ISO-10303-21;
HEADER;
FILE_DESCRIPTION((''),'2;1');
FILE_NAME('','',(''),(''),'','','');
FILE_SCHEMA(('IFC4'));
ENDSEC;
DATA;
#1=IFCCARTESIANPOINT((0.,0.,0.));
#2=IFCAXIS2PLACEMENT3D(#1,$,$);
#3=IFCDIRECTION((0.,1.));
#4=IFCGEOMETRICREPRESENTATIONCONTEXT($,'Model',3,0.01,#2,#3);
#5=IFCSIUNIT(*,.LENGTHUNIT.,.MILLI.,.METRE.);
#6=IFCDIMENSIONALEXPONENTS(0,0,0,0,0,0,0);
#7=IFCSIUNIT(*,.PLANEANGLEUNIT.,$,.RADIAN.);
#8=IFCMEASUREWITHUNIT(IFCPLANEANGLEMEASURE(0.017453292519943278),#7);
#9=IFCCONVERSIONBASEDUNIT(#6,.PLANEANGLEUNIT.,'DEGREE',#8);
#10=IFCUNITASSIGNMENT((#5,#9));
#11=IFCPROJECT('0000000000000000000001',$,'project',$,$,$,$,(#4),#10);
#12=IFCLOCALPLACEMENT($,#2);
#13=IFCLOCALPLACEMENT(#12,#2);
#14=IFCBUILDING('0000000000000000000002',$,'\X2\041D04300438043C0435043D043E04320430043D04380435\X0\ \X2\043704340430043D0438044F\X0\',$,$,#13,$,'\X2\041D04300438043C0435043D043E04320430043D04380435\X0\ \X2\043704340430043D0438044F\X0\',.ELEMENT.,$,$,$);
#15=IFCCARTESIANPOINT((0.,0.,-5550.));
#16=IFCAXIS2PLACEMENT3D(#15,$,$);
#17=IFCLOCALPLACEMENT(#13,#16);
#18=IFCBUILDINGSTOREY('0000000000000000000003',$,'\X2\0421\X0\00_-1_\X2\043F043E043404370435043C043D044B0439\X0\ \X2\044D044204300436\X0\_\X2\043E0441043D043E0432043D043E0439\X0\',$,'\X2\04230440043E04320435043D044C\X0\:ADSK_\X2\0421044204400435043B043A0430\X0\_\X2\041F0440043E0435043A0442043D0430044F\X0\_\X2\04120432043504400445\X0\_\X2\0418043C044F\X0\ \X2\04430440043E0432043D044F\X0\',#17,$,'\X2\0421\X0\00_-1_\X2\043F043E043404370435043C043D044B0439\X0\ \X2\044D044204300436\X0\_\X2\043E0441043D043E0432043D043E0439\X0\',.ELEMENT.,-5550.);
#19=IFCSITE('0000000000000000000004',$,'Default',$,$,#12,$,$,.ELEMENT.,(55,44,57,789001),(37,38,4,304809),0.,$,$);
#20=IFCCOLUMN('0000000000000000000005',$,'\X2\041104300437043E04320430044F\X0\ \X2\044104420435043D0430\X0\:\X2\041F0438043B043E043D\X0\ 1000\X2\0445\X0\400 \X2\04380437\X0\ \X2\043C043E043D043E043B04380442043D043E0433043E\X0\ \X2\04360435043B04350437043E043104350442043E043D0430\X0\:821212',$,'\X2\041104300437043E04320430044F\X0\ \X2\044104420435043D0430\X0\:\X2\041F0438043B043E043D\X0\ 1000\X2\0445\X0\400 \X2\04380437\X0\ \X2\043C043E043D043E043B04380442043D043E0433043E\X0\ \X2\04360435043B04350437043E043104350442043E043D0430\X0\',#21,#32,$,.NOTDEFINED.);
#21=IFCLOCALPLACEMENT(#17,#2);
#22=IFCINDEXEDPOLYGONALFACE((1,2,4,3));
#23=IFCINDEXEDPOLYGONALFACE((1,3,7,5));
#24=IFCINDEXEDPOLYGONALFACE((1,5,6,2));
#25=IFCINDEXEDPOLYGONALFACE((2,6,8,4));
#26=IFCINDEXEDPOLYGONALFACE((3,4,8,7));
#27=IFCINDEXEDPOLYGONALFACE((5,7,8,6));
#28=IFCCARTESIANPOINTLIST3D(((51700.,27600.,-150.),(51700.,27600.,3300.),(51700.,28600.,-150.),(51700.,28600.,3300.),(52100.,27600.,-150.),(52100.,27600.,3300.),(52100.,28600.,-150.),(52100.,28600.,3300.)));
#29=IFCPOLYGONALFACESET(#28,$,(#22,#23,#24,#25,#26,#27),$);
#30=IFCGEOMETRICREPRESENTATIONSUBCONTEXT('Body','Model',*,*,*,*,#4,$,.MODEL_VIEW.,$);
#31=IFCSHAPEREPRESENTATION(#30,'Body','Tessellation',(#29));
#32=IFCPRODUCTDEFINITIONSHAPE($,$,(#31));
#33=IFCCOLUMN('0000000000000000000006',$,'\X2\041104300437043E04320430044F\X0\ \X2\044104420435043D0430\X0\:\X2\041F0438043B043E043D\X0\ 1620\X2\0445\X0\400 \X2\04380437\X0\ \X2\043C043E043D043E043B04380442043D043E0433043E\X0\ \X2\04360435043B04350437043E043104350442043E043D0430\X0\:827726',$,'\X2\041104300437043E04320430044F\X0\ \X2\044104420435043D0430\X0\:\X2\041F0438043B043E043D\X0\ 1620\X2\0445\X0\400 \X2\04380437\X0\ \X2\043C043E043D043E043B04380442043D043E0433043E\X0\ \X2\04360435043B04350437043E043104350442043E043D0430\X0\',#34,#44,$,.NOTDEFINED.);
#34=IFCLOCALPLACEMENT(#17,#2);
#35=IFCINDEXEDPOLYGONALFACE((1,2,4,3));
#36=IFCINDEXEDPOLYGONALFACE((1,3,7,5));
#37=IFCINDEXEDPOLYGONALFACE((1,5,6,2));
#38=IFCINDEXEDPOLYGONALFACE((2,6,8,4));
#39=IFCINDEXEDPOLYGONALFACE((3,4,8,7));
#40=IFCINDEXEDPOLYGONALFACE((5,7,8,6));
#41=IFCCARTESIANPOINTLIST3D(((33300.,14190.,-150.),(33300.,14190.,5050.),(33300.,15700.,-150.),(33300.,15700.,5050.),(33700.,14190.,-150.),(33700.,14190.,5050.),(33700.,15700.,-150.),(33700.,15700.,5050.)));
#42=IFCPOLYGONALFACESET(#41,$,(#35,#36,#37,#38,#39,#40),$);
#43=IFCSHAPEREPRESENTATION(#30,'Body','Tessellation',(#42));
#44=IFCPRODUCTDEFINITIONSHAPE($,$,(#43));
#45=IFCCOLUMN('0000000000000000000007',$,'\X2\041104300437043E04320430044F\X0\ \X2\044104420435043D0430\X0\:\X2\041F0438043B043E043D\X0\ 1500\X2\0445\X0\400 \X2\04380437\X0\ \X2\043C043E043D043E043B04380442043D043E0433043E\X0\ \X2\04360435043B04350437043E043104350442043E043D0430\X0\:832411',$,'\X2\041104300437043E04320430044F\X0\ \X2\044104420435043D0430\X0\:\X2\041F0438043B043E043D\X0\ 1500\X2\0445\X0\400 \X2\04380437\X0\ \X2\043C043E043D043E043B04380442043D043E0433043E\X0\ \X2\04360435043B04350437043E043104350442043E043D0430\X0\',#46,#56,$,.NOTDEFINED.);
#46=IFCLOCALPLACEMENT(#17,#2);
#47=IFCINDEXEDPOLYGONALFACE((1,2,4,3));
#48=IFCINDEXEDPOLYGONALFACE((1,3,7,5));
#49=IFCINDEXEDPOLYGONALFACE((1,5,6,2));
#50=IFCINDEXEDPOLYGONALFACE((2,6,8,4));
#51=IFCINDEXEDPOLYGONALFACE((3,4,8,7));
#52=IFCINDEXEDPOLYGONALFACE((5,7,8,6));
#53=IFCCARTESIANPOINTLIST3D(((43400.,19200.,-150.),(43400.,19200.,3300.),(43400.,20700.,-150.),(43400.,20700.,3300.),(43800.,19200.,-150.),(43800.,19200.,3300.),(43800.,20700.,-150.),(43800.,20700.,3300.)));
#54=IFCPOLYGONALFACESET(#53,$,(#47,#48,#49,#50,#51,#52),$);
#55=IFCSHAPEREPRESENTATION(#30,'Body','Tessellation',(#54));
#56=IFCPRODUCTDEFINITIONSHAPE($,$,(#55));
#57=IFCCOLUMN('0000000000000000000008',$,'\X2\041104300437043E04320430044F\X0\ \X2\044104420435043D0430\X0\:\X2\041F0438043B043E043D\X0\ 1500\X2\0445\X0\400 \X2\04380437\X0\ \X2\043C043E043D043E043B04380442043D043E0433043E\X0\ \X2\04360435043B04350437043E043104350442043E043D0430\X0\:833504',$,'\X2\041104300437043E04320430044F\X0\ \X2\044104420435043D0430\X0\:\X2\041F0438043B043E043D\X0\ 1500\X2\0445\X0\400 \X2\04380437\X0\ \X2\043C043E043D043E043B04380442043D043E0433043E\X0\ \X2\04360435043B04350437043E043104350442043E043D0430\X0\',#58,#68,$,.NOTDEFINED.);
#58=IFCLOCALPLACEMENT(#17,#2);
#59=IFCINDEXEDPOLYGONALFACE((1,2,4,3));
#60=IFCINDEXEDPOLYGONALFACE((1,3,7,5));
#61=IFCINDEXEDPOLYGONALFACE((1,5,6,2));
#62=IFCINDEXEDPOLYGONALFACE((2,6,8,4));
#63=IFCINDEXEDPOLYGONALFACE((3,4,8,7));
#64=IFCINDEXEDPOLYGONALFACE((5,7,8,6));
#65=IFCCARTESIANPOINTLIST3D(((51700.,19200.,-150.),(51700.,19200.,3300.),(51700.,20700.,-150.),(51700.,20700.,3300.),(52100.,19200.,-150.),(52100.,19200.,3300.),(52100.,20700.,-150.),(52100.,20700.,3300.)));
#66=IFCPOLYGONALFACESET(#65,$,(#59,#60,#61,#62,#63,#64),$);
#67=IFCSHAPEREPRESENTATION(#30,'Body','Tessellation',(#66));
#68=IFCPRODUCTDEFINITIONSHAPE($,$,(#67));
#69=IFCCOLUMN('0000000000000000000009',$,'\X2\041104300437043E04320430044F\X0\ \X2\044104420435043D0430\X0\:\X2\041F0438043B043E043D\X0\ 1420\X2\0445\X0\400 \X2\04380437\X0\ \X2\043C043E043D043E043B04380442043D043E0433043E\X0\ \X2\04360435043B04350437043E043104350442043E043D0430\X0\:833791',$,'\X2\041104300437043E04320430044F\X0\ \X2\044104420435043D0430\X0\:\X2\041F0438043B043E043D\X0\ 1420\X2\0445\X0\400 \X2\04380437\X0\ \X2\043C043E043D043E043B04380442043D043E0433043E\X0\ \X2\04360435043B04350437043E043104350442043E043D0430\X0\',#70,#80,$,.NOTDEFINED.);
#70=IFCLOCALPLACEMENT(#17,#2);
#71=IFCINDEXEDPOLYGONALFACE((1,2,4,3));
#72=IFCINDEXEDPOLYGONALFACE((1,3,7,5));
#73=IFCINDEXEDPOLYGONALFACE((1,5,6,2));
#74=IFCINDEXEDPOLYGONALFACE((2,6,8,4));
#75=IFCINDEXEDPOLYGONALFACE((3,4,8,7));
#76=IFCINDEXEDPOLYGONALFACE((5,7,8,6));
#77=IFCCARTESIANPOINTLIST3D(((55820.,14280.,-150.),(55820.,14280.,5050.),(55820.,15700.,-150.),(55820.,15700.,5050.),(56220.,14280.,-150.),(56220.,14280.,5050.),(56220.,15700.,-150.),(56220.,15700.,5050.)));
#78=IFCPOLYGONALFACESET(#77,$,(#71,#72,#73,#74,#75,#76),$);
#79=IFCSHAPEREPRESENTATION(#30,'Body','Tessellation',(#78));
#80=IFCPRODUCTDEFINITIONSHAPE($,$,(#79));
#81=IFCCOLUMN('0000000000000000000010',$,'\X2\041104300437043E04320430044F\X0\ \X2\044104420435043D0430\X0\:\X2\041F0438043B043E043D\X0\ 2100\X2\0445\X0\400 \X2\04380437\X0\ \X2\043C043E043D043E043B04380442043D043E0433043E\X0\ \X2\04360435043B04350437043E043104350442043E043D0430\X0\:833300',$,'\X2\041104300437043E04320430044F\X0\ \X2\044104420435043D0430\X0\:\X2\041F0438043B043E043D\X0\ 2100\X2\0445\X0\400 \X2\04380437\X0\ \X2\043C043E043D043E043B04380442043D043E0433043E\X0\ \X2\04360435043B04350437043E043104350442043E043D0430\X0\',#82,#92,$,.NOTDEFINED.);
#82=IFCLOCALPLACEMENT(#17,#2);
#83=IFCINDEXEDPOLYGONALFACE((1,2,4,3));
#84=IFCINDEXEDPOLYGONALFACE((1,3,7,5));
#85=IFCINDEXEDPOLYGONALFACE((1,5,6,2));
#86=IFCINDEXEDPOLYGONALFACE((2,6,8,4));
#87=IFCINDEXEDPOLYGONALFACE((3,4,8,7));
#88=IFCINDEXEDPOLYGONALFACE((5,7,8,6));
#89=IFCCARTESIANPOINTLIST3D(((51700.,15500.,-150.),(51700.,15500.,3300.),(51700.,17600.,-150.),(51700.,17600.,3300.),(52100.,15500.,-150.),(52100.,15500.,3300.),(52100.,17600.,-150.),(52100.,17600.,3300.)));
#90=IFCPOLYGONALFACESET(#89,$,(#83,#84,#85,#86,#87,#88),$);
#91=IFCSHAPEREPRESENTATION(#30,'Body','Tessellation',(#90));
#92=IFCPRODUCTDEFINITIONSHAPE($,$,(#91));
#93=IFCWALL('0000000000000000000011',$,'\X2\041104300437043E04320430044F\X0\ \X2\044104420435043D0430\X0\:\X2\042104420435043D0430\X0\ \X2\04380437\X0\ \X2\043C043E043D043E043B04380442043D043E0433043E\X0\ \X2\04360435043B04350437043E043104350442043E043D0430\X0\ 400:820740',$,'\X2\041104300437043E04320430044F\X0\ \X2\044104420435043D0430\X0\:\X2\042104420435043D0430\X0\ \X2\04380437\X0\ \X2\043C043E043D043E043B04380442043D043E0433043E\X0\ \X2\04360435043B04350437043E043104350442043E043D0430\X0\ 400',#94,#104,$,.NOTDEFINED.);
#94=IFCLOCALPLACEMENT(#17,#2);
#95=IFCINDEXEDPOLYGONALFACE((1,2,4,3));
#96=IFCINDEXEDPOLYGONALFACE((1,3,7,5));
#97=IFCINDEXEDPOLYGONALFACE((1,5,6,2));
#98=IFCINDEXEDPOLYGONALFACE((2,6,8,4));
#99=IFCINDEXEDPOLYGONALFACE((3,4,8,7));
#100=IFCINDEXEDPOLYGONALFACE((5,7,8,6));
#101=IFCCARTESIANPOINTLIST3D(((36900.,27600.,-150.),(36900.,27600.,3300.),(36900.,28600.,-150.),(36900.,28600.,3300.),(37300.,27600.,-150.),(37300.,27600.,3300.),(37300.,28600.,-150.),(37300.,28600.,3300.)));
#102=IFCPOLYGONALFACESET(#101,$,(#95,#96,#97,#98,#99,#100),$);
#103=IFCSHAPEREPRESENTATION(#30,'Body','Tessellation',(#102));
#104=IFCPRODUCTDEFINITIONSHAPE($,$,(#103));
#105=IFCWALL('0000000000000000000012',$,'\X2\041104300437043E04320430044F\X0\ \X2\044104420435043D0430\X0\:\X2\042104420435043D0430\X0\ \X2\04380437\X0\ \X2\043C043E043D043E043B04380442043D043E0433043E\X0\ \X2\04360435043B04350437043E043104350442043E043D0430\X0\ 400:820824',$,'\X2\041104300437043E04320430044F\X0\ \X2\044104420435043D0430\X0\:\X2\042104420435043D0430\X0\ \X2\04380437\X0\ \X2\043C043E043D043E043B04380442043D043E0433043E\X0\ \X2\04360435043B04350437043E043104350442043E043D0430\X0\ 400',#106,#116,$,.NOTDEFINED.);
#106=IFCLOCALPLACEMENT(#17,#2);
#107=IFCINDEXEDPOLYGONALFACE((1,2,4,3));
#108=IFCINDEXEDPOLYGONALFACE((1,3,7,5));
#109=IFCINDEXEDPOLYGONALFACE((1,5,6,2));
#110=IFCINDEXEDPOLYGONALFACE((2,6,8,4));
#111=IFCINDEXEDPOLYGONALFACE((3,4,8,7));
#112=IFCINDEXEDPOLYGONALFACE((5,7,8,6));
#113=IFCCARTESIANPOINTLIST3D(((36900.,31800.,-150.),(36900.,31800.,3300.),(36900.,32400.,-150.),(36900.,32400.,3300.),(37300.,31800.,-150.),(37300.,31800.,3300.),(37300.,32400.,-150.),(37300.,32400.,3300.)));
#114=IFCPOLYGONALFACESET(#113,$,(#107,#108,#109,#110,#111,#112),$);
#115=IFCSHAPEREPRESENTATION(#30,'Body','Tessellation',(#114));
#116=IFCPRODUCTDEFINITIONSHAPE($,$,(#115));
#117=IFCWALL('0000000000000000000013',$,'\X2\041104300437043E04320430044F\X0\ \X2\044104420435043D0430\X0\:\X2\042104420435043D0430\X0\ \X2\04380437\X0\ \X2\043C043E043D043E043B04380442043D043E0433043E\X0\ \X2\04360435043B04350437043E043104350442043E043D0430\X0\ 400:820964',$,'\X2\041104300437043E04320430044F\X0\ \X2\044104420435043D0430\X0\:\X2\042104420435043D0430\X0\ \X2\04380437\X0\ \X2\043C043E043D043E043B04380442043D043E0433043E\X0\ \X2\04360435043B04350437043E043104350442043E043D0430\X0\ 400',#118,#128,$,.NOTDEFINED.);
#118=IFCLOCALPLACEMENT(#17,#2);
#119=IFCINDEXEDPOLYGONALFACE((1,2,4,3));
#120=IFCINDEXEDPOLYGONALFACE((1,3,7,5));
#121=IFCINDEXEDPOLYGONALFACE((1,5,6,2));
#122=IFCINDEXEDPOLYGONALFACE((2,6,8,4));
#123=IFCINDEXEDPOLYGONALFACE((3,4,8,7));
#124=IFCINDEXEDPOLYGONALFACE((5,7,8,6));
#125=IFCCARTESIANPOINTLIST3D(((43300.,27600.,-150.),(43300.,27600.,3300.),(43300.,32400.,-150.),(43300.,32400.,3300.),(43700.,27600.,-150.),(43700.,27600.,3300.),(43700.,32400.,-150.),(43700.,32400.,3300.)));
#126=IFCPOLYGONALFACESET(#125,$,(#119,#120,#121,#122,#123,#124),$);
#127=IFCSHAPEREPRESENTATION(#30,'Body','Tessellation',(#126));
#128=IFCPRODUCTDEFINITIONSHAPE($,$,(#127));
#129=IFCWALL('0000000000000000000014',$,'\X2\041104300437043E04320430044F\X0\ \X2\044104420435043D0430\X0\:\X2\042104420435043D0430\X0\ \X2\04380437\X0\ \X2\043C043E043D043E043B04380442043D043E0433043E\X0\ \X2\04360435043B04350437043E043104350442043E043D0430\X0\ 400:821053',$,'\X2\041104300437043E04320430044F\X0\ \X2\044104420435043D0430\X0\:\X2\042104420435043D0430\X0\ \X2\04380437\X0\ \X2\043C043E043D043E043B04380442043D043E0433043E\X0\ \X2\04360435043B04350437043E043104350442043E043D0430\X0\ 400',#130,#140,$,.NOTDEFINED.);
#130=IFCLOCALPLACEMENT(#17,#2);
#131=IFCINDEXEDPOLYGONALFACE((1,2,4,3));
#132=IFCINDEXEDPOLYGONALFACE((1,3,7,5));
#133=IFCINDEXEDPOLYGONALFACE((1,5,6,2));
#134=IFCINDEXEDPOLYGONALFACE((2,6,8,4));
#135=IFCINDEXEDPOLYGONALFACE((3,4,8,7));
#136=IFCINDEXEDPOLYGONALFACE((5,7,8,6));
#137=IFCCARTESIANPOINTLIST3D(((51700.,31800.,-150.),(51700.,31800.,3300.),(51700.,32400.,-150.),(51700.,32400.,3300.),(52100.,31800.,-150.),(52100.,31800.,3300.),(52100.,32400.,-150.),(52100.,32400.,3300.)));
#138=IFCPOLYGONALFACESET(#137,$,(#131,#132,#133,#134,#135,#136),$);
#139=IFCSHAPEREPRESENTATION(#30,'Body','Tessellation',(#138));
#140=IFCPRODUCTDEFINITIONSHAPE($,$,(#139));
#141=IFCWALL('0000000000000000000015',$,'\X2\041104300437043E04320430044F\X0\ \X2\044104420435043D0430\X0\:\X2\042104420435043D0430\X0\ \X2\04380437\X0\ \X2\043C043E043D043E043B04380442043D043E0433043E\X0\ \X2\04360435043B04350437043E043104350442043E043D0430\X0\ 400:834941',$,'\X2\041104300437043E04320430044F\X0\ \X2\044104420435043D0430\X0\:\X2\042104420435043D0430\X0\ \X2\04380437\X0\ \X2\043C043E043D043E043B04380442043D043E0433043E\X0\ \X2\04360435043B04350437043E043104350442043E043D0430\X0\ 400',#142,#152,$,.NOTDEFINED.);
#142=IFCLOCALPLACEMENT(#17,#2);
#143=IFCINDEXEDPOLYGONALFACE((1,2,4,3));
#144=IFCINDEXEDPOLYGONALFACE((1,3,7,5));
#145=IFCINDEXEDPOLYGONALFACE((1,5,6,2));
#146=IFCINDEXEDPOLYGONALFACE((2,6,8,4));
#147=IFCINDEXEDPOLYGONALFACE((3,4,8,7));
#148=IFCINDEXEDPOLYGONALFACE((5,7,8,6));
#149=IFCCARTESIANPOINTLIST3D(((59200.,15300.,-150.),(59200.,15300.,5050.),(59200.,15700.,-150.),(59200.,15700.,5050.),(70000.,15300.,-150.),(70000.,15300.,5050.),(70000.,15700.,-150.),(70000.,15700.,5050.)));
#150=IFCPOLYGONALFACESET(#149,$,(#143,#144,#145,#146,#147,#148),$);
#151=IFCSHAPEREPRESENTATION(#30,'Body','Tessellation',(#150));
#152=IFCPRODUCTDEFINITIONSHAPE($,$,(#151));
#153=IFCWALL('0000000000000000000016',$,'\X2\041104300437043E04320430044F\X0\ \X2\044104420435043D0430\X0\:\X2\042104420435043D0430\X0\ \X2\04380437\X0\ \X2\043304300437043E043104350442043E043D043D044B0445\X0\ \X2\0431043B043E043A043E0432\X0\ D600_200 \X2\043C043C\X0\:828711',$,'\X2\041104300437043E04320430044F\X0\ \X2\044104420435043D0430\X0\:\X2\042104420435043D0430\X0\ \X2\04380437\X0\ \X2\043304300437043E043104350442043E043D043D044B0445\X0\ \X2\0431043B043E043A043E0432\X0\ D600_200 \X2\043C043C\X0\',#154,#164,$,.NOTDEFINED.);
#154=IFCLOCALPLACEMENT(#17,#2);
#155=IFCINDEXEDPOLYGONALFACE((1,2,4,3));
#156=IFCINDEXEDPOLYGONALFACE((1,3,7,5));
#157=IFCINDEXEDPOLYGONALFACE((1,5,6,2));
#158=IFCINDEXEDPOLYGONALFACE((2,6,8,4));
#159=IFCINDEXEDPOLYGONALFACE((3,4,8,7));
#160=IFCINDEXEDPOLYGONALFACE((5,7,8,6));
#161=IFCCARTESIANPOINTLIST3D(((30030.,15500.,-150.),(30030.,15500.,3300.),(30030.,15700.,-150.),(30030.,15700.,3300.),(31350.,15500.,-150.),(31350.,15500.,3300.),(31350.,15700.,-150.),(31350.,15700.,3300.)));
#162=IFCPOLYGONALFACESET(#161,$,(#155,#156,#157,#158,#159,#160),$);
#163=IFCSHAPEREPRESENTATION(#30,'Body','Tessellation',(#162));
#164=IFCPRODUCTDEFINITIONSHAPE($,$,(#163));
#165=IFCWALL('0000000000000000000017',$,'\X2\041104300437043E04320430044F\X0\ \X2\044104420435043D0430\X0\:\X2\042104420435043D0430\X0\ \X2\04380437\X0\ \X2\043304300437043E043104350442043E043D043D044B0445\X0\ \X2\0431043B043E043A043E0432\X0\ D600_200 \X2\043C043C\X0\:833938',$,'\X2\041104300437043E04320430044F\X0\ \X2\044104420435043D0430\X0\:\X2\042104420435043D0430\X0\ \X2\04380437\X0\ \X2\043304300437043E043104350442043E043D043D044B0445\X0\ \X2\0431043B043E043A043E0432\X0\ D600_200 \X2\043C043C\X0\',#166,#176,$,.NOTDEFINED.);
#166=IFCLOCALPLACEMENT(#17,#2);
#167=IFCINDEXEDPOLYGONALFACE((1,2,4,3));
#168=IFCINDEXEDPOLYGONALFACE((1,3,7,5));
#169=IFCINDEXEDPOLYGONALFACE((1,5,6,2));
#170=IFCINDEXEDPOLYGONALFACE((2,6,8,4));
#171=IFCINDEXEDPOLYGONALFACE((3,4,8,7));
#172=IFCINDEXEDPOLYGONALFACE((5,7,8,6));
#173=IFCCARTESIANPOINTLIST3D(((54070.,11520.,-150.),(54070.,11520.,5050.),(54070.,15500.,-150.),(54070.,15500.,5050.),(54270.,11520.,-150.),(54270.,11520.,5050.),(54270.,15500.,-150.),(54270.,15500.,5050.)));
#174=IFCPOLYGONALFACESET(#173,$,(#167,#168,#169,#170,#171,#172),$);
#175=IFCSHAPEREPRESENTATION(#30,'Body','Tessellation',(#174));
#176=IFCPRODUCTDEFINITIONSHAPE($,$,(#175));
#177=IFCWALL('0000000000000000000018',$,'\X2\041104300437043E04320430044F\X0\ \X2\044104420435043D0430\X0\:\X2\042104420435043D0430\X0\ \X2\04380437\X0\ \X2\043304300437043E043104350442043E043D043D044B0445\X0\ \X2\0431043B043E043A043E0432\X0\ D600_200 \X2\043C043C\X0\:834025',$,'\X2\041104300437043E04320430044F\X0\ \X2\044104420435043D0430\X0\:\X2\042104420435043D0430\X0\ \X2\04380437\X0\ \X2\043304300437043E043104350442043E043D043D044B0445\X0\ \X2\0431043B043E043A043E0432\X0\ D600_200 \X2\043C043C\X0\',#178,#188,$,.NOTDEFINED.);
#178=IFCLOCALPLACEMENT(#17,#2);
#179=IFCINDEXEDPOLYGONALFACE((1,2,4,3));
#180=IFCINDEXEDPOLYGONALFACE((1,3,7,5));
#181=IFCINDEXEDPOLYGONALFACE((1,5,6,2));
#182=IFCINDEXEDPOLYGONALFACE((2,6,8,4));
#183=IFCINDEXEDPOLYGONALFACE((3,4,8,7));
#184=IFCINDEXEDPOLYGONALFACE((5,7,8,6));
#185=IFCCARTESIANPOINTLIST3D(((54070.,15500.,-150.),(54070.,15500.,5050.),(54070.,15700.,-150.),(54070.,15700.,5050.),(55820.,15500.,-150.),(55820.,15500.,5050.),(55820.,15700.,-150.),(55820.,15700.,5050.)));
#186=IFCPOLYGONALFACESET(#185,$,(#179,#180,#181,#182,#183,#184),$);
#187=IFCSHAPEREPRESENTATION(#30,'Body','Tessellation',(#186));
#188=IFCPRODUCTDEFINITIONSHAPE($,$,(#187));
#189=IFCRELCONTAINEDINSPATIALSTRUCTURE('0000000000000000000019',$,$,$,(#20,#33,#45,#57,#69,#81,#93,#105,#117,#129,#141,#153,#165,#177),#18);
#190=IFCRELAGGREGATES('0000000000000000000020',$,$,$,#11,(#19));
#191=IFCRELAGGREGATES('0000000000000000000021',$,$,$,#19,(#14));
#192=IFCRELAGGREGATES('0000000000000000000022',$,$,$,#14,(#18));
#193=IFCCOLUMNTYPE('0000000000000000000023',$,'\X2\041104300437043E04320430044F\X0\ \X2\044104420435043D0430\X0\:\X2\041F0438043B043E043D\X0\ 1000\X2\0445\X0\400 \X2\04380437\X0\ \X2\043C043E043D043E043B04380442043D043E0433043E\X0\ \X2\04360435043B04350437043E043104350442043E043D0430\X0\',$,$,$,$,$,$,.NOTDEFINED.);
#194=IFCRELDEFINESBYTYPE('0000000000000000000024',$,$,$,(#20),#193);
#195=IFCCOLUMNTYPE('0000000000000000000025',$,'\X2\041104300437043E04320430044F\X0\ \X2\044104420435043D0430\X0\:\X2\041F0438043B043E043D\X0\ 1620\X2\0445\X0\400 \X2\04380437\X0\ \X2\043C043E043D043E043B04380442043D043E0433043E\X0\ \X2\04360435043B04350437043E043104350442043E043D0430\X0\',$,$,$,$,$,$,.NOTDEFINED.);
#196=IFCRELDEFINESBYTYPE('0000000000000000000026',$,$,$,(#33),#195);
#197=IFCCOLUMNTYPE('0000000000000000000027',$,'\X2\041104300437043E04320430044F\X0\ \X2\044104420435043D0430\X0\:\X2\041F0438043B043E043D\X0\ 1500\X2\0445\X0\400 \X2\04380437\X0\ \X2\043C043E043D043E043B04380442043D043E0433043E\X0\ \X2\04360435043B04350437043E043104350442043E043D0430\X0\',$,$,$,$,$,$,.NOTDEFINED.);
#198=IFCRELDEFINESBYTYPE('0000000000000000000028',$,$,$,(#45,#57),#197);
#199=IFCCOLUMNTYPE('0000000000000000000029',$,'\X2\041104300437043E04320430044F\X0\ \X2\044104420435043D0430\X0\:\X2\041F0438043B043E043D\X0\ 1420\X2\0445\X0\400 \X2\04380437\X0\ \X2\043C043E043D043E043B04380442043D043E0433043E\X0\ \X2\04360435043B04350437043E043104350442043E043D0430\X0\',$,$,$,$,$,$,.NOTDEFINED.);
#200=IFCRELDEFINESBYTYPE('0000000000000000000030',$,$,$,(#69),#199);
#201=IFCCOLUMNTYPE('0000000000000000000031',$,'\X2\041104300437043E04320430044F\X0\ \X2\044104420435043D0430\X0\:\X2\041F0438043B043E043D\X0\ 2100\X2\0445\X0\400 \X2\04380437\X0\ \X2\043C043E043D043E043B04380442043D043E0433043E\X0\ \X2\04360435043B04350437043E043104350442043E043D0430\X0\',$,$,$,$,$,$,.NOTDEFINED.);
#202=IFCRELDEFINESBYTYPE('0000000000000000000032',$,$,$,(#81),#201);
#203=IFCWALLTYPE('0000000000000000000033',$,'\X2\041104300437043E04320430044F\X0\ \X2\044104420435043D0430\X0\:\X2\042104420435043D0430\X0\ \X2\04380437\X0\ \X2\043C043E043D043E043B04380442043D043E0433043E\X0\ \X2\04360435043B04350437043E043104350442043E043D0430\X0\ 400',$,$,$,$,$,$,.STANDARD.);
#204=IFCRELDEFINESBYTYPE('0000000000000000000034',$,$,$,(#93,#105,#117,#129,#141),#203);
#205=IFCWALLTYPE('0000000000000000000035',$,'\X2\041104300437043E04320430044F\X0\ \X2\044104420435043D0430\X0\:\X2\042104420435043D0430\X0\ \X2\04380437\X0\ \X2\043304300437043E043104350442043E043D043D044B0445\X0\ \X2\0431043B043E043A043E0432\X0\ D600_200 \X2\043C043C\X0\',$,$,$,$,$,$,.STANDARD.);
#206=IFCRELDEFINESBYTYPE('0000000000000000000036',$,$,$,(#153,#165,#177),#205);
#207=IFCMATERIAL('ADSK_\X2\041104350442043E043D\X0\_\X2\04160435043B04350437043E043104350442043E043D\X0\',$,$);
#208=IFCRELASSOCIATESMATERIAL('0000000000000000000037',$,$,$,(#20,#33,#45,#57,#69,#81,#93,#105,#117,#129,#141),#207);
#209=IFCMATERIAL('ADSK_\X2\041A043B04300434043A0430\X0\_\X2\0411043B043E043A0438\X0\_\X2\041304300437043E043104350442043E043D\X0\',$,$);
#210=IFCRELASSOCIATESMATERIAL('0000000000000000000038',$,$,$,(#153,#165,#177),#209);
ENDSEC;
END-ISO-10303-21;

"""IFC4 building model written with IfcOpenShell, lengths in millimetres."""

from ifc_helpers import new_model, entity, si_unit, converted_unit, direction, frame, origin, place, context, subcontext, project, spatial, indexed_curve, outline, extrude, material, type_object, element, save


model = new_model("IFC4")

# Units and contexts
model_context = context("Model", 3, precision=0.01, world=origin(), true_north=direction((0.0, 1.0)))
body_context = subcontext(model_context, "Body", "Model", "MODEL_VIEW")
ifc_project = project(units=[si_unit("LENGTHUNIT", "METRE", prefix="MILLI"), converted_unit("PLANEANGLEUNIT", "DEGREE", entity("IfcPlaneAngleMeasure", 0.017453292519943278), si_unit("PLANEANGLEUNIT", "RADIAN"), dimensions=[0, 0, 0, 0, 0, 0, 0])], contexts=[model_context])

# Site, building, storey
site_placement = place(None, origin())
site = spatial("IfcSite", under=ifc_project, at=site_placement, Name="Default", CompositionType="ELEMENT", RefLatitude=(55, 44, 57, 789001), RefLongitude=(37, 38, 4, 304809), RefElevation=0.0)
building_placement = place(site_placement, origin())
building = spatial("IfcBuilding", under=site, at=building_placement, Name="Наименование здания", LongName="Наименование здания", CompositionType="ELEMENT")
storey_placement = place(building_placement, frame((0.0, 0.0, -5550.0)))
storey = spatial("IfcBuildingStorey", under=building, at=storey_placement, Name="С00_-1_подземный этаж_основной", ObjectType="Уровень:ADSK_Стрелка_Проектная_Вверх_Имя уровня", LongName="С00_-1_подземный этаж_основной", CompositionType="ELEMENT", Elevation=-5550.0)

# Columns
ifc_material_1 = material(Name="ADSK_Бетон_Железобетон")
column_type_1 = type_object("IfcColumnType", Name="Базовая стена:Пилон 1000х400 из монолитного железобетона", PredefinedType="NOTDEFINED")
column_1_placement = place(storey_placement, frame((51900.0, 27600.0, -150.0), z_axis=(0.0, 0.0, 1.0), x_axis=(0.0, 1.0, 0.0)))
element("IfcColumn", 1, at=column_1_placement, inside=storey, type_object=column_type_1, material=ifc_material_1, Name="Базовая стена:Пилон 1000х400 из монолитного железобетона:821212", ObjectType="Базовая стена:Пилон 1000х400 из монолитного железобетона", PredefinedType="NOTDEFINED", context=body_context, shape_type="SweptSolid", body=[
    extrude(outline(indexed_curve([(1000.0, 200.0), (0.0, 200.0), (0.0, -200.0), (1000.0, -200.0), (1000.0, 200.0)], self_intersect=False)), origin(), (0.0, 0.0, 1.0), 3450.0),
])
column_type_2 = type_object("IfcColumnType", Name="Базовая стена:Пилон 1620х400 из монолитного железобетона", PredefinedType="NOTDEFINED")
column_2_placement = place(storey_placement, frame((33500.0, 15700.0, -150.0), z_axis=(0.0, 0.0, 1.0), x_axis=(0.0, -1.0, 0.0)))
element("IfcColumn", 2, at=column_2_placement, inside=storey, type_object=column_type_2, material=ifc_material_1, Name="Базовая стена:Пилон 1620х400 из монолитного железобетона:827726", ObjectType="Базовая стена:Пилон 1620х400 из монолитного железобетона", PredefinedType="NOTDEFINED", context=body_context, shape_type="SweptSolid", body=[
    extrude(outline(indexed_curve([(1510.0, 200.0), (0.0, 200.0), (0.0, -200.0), (1510.0, -200.0), (1510.0, 200.0)], self_intersect=False)), origin(), (0.0, 0.0, 1.0), 5200.0),
])
column_type_3 = type_object("IfcColumnType", Name="Базовая стена:Пилон 1500х400 из монолитного железобетона", PredefinedType="NOTDEFINED")
column_3_placement = place(storey_placement, frame((43600.0, 20700.0, -150.0), z_axis=(0.0, 0.0, 1.0), x_axis=(0.0, -1.0, 0.0)))
element("IfcColumn", 3, at=column_3_placement, inside=storey, type_object=column_type_3, material=ifc_material_1, Name="Базовая стена:Пилон 1500х400 из монолитного железобетона:832411", ObjectType="Базовая стена:Пилон 1500х400 из монолитного железобетона", PredefinedType="NOTDEFINED", context=body_context, shape_type="SweptSolid", body=[
    extrude(outline(indexed_curve([(1500.0, 200.0), (0.0, 200.0), (0.0, -200.0), (1500.0, -200.0), (1500.0, 200.0)], self_intersect=False)), origin(), (0.0, 0.0, 1.0), 3450.0),
])
column_4_placement = place(storey_placement, frame((51900.0, 19200.0, -150.0), z_axis=(0.0, 0.0, 1.0), x_axis=(0.0, 1.0, 0.0)))
element("IfcColumn", 4, at=column_4_placement, inside=storey, type_object=column_type_3, material=ifc_material_1, Name="Базовая стена:Пилон 1500х400 из монолитного железобетона:833504", ObjectType="Базовая стена:Пилон 1500х400 из монолитного железобетона", PredefinedType="NOTDEFINED", context=body_context, shape_type="SweptSolid", body=[
    extrude(outline(indexed_curve([(1500.0, 200.0), (0.0, 200.0), (0.0, -200.0), (1500.0, -200.0), (1500.0, 200.0)], self_intersect=False)), origin(), (0.0, 0.0, 1.0), 3450.0),
])
column_type_4 = type_object("IfcColumnType", Name="Базовая стена:Пилон 1420х400 из монолитного железобетона", PredefinedType="NOTDEFINED")
column_5_placement = place(storey_placement, frame((56020.0, 14280.0, -150.0), z_axis=(0.0, 0.0, 1.0), x_axis=(0.0, 1.0, 0.0)))
element("IfcColumn", 5, at=column_5_placement, inside=storey, type_object=column_type_4, material=ifc_material_1, Name="Базовая стена:Пилон 1420х400 из монолитного железобетона:833791", ObjectType="Базовая стена:Пилон 1420х400 из монолитного железобетона", PredefinedType="NOTDEFINED", context=body_context, shape_type="SweptSolid", body=[
    extrude(outline(indexed_curve([(1420.0, 200.0), (0.0, 200.0), (0.0, -200.0), (1420.0, -200.0), (1420.0, 200.0)], self_intersect=False)), origin(), (0.0, 0.0, 1.0), 5200.0),
])
column_type_5 = type_object("IfcColumnType", Name="Базовая стена:Пилон 2100х400 из монолитного железобетона", PredefinedType="NOTDEFINED")
column_6_placement = place(storey_placement, frame((51900.0, 15500.0, -150.0), z_axis=(0.0, 0.0, 1.0), x_axis=(0.0, 1.0, 0.0)))
element("IfcColumn", 6, at=column_6_placement, inside=storey, type_object=column_type_5, material=ifc_material_1, Name="Базовая стена:Пилон 2100х400 из монолитного железобетона:833300", ObjectType="Базовая стена:Пилон 2100х400 из монолитного железобетона", PredefinedType="NOTDEFINED", context=body_context, shape_type="SweptSolid", body=[
    extrude(outline(indexed_curve([(2100.0, 200.0), (0.0, 200.0), (0.0, -200.0), (2100.0, -200.0), (2100.0, 200.0)], self_intersect=False)), origin(), (0.0, 0.0, 1.0), 3450.0),
])

# Walls
wall_type_1 = type_object("IfcWallType", Name="Базовая стена:Стена из монолитного железобетона 400", PredefinedType="STANDARD")
wall_1_placement = place(storey_placement, frame((37100.0, 27600.0, -150.0), z_axis=(0.0, 0.0, 1.0), x_axis=(0.0, 1.0, 0.0)))
element("IfcWall", 7, at=wall_1_placement, inside=storey, type_object=wall_type_1, material=ifc_material_1, Name="Базовая стена:Стена из монолитного железобетона 400:820740", ObjectType="Базовая стена:Стена из монолитного железобетона 400", PredefinedType="NOTDEFINED", context=body_context, shape_type="SweptSolid", body=[
    extrude(outline(indexed_curve([(1000.0, 200.0), (0.0, 200.0), (0.0, -200.0), (1000.0, -200.0), (1000.0, 200.0)], self_intersect=False)), origin(), (0.0, 0.0, 1.0), 3450.0),
])
wall_2_placement = place(storey_placement, frame((37100.0, 31800.0, -150.0), z_axis=(0.0, 0.0, 1.0), x_axis=(0.0, 1.0, 0.0)))
element("IfcWall", 8, at=wall_2_placement, inside=storey, type_object=wall_type_1, material=ifc_material_1, Name="Базовая стена:Стена из монолитного железобетона 400:820824", ObjectType="Базовая стена:Стена из монолитного железобетона 400", PredefinedType="NOTDEFINED", context=body_context, shape_type="SweptSolid", body=[
    extrude(outline(indexed_curve([(600.0, 200.0), (0.0, 200.0), (0.0, -200.0), (600.0, -200.0), (600.0, 200.0)], self_intersect=False)), origin(), (0.0, 0.0, 1.0), 3450.0),
])
wall_3_placement = place(storey_placement, frame((43500.0, 27600.0, -150.0), z_axis=(0.0, 0.0, 1.0), x_axis=(0.0, 1.0, 0.0)))
element("IfcWall", 9, at=wall_3_placement, inside=storey, type_object=wall_type_1, material=ifc_material_1, Name="Базовая стена:Стена из монолитного железобетона 400:820964", ObjectType="Базовая стена:Стена из монолитного железобетона 400", PredefinedType="NOTDEFINED", context=body_context, shape_type="SweptSolid", body=[
    extrude(outline(indexed_curve([(4800.0, 200.0), (0.0, 200.0), (0.0, -200.0), (4800.0, -200.0), (4800.0, 200.0)], self_intersect=False)), origin(), (0.0, 0.0, 1.0), 3450.0),
])
wall_4_placement = place(storey_placement, frame((51900.0, 31800.0, -150.0), z_axis=(0.0, 0.0, 1.0), x_axis=(0.0, 1.0, 0.0)))
element("IfcWall", 10, at=wall_4_placement, inside=storey, type_object=wall_type_1, material=ifc_material_1, Name="Базовая стена:Стена из монолитного железобетона 400:821053", ObjectType="Базовая стена:Стена из монолитного железобетона 400", PredefinedType="NOTDEFINED", context=body_context, shape_type="SweptSolid", body=[
    extrude(outline(indexed_curve([(600.0, 200.0), (0.0, 200.0), (0.0, -200.0), (600.0, -200.0), (600.0, 200.0)], self_intersect=False)), origin(), (0.0, 0.0, 1.0), 3450.0),
])
wall_5_placement = place(storey_placement, frame((59200.0, 15500.0, -150.0)))
element("IfcWall", 11, at=wall_5_placement, inside=storey, type_object=wall_type_1, material=ifc_material_1, Name="Базовая стена:Стена из монолитного железобетона 400:834941", ObjectType="Базовая стена:Стена из монолитного железобетона 400", PredefinedType="NOTDEFINED", context=body_context, shape_type="SweptSolid", body=[
    extrude(outline(indexed_curve([(10800.0, 200.0), (0.0, 200.0), (0.0, -200.0), (10800.0, -200.0), (10800.0, 200.0)], self_intersect=False)), origin(), (0.0, 0.0, 1.0), 5200.0),
])
ifc_material_2 = material(Name="ADSK_Кладка_Блоки_Газобетон")
wall_type_2 = type_object("IfcWallType", Name="Базовая стена:Стена из газобетонных блоков D600_200 мм", PredefinedType="STANDARD")
wall_6_placement = place(storey_placement, frame((31350.0, 15600.0, -150.0), z_axis=(0.0, 0.0, 1.0), x_axis=(-1.0, 0.0, 0.0)))
element("IfcWall", 12, at=wall_6_placement, inside=storey, type_object=wall_type_2, material=ifc_material_2, Name="Базовая стена:Стена из газобетонных блоков D600_200 мм:828711", ObjectType="Базовая стена:Стена из газобетонных блоков D600_200 мм", PredefinedType="NOTDEFINED", context=body_context, shape_type="SweptSolid", body=[
    extrude(outline(indexed_curve([(1320.0, 100.0), (0.0, 100.0), (0.0, -100.0), (1320.0, -100.0), (1320.0, 100.0)], self_intersect=False)), origin(), (0.0, 0.0, 1.0), 3450.0),
])
wall_7_placement = place(storey_placement, frame((54170.0, 11520.0, -150.0), z_axis=(0.0, 0.0, 1.0), x_axis=(0.0, 1.0, 0.0)))
element("IfcWall", 13, at=wall_7_placement, inside=storey, type_object=wall_type_2, material=ifc_material_2, Name="Базовая стена:Стена из газобетонных блоков D600_200 мм:833938", ObjectType="Базовая стена:Стена из газобетонных блоков D600_200 мм", PredefinedType="NOTDEFINED", context=body_context, shape_type="SweptSolid", body=[
    extrude(outline(indexed_curve([(3980.0, 100.0), (0.0, 100.0), (0.0, -100.0), (3980.0, -100.0), (3980.0, 100.0)], self_intersect=False)), origin(), (0.0, 0.0, 1.0), 5200.0),
])
wall_8_placement = place(storey_placement, frame((55820.0, 15600.0, -150.0), z_axis=(0.0, 0.0, 1.0), x_axis=(-1.0, 0.0, 0.0)))
element("IfcWall", 14, at=wall_8_placement, inside=storey, type_object=wall_type_2, material=ifc_material_2, Name="Базовая стена:Стена из газобетонных блоков D600_200 мм:834025", ObjectType="Базовая стена:Стена из газобетонных блоков D600_200 мм", PredefinedType="NOTDEFINED", context=body_context, shape_type="SweptSolid", body=[
    extrude(outline(indexed_curve([(1750.0, 100.0), (0.0, 100.0), (0.0, -100.0), (1750.0, -100.0), (1750.0, 100.0)], self_intersect=False)), origin(), (0.0, 0.0, 1.0), 5200.0),
])

save(model, "model.ifc")
